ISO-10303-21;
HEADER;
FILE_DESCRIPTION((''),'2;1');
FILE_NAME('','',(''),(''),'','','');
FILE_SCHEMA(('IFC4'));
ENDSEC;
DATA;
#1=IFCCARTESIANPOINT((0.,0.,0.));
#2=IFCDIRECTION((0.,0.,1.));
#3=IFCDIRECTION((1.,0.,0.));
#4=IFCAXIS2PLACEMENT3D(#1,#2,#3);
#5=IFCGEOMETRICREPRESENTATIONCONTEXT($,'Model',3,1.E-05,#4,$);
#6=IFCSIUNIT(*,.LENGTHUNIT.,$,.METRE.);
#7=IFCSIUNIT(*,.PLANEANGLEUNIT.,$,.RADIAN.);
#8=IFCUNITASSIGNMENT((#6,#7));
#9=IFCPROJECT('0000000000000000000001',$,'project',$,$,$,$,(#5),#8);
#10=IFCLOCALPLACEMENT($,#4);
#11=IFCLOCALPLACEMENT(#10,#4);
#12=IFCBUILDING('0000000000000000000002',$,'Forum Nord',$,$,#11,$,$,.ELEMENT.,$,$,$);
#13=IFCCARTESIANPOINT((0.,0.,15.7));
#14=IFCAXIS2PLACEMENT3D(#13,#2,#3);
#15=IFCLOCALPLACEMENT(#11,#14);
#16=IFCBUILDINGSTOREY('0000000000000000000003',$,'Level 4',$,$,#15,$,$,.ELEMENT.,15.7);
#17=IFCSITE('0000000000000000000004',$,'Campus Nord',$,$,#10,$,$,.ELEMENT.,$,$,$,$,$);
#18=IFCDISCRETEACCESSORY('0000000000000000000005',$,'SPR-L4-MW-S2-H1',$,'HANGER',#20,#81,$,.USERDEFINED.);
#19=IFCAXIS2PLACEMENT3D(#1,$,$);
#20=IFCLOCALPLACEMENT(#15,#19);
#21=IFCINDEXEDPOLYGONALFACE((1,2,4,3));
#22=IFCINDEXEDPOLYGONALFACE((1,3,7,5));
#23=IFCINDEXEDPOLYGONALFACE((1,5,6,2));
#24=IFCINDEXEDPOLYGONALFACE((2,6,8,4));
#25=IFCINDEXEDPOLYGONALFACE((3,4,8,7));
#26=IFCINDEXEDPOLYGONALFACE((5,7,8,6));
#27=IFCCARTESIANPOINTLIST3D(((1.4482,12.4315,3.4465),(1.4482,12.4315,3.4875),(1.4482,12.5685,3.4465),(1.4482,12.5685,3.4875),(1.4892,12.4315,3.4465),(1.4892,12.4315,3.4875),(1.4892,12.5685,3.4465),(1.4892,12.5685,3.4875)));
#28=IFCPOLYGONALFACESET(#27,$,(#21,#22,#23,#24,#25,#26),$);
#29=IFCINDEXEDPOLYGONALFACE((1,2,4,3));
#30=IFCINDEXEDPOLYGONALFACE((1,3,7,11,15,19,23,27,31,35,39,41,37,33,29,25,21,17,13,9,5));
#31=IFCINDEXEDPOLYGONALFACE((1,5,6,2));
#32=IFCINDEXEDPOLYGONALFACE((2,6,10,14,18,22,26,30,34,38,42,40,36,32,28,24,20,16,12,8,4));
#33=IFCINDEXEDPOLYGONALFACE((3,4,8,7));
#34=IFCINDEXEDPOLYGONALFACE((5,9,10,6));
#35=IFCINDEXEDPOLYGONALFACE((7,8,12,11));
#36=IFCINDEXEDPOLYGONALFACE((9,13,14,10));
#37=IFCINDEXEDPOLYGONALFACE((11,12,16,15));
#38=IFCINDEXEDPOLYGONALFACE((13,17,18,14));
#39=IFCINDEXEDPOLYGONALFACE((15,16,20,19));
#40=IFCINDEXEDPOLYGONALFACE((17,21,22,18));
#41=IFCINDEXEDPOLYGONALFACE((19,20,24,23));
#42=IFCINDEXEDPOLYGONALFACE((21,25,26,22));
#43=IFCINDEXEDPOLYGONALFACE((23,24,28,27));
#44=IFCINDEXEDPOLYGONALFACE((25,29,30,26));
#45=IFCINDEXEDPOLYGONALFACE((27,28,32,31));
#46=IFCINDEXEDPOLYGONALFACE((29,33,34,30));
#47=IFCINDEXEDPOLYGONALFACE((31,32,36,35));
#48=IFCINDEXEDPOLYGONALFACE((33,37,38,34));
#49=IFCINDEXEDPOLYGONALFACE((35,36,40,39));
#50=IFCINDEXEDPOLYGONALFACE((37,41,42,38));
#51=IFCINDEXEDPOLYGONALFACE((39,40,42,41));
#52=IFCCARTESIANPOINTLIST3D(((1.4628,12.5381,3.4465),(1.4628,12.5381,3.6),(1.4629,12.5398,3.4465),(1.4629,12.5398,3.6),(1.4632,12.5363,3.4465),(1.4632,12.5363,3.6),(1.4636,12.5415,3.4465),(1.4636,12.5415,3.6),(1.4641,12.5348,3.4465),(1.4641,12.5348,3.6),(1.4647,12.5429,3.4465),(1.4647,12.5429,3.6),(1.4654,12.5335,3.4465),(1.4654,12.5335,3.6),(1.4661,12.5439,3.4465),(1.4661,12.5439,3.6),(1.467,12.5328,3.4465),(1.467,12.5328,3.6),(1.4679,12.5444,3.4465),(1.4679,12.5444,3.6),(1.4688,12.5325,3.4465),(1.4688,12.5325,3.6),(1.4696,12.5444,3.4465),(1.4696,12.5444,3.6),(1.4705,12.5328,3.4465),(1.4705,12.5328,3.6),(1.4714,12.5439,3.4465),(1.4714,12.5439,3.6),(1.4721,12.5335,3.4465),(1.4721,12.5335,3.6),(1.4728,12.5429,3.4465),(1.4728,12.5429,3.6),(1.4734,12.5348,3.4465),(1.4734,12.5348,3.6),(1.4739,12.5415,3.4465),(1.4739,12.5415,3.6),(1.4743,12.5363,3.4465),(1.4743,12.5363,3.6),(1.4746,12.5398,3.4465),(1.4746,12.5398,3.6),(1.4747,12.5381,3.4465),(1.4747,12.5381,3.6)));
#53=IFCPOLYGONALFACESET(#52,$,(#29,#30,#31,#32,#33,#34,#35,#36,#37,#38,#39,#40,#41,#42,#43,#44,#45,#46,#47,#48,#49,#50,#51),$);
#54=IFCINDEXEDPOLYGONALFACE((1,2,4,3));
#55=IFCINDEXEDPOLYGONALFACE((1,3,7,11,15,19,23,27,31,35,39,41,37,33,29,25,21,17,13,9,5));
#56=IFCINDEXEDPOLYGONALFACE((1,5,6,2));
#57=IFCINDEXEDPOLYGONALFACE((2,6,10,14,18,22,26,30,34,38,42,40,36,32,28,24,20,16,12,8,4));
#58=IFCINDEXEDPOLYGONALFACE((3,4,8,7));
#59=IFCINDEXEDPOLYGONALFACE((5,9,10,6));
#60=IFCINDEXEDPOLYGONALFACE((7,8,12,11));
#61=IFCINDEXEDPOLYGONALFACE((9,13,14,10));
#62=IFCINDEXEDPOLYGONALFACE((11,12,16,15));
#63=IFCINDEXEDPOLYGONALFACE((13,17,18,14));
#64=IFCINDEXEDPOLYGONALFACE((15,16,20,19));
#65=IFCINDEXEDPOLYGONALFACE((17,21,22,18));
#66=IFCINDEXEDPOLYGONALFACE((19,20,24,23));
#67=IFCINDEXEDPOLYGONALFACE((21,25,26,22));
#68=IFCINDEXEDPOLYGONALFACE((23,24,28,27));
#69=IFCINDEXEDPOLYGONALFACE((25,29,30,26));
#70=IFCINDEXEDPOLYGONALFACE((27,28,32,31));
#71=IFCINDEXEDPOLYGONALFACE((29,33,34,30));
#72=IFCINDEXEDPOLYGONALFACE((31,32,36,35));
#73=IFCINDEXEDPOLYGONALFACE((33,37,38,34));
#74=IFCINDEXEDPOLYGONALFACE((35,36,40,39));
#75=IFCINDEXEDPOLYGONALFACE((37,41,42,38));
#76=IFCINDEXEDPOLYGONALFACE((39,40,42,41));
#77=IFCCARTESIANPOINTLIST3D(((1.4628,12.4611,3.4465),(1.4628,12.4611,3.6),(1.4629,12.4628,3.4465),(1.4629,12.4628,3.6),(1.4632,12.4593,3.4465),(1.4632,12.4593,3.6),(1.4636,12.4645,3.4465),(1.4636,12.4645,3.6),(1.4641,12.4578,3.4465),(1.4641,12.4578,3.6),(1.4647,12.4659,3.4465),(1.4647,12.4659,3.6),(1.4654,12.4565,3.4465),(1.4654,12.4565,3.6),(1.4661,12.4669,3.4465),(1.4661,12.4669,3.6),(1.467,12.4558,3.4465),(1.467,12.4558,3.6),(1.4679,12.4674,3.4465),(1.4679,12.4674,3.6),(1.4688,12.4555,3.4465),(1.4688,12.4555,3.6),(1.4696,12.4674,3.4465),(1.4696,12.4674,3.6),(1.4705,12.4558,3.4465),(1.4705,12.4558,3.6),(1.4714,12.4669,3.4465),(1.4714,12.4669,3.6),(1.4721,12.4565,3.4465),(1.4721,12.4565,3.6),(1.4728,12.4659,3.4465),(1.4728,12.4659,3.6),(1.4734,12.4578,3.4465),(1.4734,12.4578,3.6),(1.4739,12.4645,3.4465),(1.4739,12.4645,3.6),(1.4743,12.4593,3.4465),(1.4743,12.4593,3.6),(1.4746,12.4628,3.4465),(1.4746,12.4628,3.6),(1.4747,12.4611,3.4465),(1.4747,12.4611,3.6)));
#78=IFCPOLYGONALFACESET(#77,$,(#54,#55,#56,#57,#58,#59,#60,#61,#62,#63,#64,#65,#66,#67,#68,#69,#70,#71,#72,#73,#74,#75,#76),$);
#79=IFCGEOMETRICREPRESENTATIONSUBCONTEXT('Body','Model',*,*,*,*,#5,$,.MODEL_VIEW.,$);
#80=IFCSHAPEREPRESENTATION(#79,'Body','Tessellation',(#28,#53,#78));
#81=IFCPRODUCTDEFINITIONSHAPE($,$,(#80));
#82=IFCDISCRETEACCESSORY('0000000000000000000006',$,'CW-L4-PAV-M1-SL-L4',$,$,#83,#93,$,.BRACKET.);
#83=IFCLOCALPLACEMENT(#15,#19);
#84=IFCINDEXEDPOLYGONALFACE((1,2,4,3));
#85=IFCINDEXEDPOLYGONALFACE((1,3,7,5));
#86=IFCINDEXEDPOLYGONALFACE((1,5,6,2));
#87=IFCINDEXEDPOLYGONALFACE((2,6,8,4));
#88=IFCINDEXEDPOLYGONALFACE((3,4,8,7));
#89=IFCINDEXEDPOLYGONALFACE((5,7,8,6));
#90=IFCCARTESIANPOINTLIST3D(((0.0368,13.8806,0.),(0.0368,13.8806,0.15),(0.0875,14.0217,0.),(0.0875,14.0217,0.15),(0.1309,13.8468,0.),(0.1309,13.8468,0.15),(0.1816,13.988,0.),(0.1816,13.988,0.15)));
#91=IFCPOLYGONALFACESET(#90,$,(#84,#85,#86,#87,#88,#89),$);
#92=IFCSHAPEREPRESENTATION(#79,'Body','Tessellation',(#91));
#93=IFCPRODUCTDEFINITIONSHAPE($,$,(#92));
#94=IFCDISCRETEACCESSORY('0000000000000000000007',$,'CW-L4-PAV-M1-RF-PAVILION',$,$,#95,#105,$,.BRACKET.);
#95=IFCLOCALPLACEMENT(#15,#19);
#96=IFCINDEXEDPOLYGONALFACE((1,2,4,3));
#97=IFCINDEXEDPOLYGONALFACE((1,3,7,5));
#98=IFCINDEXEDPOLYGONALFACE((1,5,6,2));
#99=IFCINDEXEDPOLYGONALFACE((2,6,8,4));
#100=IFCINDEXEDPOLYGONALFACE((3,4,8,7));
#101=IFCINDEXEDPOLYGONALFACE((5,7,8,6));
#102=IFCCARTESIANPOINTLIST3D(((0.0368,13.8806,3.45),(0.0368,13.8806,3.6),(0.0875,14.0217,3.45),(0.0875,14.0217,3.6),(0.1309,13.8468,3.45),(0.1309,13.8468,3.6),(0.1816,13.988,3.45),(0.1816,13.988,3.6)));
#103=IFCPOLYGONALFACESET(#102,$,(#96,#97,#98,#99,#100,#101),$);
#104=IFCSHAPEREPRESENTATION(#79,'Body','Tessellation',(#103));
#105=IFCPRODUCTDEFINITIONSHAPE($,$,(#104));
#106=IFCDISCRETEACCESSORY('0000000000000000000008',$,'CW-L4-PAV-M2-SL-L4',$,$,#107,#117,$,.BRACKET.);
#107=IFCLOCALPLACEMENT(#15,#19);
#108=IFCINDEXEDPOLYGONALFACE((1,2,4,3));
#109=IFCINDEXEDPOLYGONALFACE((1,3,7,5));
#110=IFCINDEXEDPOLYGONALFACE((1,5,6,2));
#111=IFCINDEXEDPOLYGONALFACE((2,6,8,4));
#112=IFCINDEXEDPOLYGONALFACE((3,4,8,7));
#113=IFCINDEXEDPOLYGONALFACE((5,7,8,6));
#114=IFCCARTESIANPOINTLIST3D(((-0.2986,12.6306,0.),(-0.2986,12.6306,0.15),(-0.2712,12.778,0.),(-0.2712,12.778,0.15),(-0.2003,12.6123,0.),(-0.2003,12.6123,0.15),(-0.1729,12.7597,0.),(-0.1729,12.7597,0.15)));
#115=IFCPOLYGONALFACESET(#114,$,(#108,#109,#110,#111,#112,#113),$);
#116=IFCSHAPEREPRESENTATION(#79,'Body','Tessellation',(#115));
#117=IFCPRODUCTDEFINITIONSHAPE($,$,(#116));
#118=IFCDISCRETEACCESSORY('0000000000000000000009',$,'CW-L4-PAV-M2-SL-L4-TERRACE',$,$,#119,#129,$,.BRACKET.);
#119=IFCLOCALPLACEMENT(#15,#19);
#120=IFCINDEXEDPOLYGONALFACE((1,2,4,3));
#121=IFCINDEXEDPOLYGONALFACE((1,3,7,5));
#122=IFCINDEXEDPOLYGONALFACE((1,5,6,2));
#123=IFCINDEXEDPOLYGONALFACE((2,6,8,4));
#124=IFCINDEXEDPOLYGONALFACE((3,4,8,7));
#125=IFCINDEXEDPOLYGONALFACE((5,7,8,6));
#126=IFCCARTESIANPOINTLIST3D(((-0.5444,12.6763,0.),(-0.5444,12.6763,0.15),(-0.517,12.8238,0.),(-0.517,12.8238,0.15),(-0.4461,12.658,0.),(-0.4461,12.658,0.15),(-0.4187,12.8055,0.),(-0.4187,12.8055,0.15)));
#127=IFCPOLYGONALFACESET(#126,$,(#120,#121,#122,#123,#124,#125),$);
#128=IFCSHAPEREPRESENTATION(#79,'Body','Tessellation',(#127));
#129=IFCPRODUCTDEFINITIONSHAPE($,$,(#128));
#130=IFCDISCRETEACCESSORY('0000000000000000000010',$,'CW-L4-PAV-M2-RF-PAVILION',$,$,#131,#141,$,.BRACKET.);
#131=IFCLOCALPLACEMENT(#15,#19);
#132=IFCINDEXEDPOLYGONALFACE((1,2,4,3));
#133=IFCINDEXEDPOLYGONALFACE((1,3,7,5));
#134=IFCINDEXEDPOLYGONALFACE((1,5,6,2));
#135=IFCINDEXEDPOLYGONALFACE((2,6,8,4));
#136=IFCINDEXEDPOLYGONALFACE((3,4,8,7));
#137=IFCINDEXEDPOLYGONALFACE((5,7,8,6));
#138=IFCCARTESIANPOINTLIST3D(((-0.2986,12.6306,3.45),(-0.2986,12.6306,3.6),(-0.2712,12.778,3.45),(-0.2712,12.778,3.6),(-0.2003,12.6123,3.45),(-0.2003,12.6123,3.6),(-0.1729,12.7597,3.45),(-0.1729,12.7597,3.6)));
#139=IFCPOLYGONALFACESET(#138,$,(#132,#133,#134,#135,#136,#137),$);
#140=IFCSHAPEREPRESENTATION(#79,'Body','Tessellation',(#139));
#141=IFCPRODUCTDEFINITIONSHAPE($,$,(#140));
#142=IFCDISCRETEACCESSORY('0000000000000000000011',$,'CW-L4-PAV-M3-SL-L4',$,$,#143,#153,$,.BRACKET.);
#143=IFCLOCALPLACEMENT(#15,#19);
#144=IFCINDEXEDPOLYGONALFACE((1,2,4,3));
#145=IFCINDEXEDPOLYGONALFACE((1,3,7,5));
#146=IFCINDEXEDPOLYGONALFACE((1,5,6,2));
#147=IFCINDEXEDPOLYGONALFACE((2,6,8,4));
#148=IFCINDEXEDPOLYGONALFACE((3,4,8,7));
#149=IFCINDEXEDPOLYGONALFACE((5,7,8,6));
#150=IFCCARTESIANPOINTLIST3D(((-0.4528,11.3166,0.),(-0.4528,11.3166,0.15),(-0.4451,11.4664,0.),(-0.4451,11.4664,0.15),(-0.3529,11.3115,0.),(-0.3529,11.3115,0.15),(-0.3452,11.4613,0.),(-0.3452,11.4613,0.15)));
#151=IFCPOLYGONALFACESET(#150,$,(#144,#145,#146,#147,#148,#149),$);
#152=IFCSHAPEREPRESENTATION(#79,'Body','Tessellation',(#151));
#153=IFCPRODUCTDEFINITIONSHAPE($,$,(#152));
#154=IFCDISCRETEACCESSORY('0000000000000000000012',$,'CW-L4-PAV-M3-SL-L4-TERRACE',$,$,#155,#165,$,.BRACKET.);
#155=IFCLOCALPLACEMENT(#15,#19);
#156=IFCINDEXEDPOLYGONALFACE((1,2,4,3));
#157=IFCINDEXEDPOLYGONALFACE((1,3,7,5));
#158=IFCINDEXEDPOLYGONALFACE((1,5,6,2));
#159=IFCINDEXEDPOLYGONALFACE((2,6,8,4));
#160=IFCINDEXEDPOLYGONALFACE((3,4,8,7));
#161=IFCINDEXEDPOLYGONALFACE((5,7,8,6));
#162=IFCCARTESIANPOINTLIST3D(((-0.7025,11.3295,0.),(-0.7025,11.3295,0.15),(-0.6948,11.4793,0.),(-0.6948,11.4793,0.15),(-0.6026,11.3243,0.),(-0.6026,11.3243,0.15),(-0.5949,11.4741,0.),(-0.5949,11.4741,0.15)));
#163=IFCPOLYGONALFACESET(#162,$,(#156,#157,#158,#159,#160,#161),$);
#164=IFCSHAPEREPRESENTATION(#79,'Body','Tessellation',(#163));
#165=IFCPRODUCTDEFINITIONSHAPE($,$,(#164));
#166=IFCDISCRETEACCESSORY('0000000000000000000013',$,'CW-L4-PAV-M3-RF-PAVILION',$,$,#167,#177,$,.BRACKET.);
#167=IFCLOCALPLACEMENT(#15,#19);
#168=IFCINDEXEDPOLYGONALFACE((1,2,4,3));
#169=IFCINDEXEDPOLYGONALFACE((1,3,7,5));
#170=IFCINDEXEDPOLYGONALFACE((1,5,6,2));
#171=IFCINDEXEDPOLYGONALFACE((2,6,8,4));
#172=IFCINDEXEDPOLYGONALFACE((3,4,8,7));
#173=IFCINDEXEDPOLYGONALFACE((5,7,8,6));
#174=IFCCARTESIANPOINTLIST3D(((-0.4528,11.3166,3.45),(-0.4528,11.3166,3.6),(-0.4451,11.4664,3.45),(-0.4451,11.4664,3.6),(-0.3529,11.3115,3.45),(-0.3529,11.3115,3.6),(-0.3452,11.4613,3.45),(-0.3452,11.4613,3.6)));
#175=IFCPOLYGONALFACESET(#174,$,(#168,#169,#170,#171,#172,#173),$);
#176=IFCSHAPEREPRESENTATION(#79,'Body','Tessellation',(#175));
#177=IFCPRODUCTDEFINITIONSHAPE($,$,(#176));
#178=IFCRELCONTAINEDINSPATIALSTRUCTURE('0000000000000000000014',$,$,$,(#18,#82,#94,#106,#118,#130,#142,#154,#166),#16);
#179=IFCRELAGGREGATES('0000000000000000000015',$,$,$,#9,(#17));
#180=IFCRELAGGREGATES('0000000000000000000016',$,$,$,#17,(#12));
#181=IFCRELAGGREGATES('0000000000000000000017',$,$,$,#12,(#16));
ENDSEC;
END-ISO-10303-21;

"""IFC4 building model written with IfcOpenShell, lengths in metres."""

from ifc_helpers import new_model, si_unit, frame, frame_2d, origin_with_axes, origin_2d_with_axis, place, context, subcontext, project, spatial, rectangle, circle, extrude, element, save


model = new_model("IFC4")

# Units and contexts
model_context = context("Model", 3, precision=1e-05, world=origin_with_axes())
body_context = subcontext(model_context, "Body", "Model", "MODEL_VIEW")
ifc_project = project(units=[si_unit("LENGTHUNIT", "METRE"), si_unit("PLANEANGLEUNIT", "RADIAN")], contexts=[model_context])

# Site, building, storey
site_placement = place(None, origin_with_axes())
site = spatial("IfcSite", under=ifc_project, at=site_placement, Name="Campus Nord", CompositionType="ELEMENT")
building_placement = place(site_placement, origin_with_axes())
building = spatial("IfcBuilding", under=site, at=building_placement, Name="Forum Nord", CompositionType="ELEMENT")
storey_placement = place(building_placement, frame((0.0, 0.0, 15.7), z_axis=(0.0, 0.0, 1.0), x_axis=(1.0, 0.0, 0.0)))
storey = spatial("IfcBuildingStorey", under=building, at=storey_placement, Name="Level 4", CompositionType="ELEMENT", Elevation=15.7)

# Discrete accessories
for number, where, z_axis, x_axis, name in (
    (1, (1.4688, 12.5, 3.4875), (0.0, 0.0, 1.0), (0.0, -1.0, 0.0), "SPR-L4-MW-S2-H1"),
):
    element("IfcDiscreteAccessory", number, at=place(storey_placement, frame(where, z_axis=z_axis, x_axis=x_axis)), inside=storey, Name=name, ObjectType="HANGER", PredefinedType="USERDEFINED", context=body_context, shape_type="SweptSolid", body=[
        extrude(rectangle(XDim=0.137, YDim=0.041, at=origin_2d_with_axis()), frame((0.0, 0.0, -0.041), z_axis=(0.0, 0.0, 1.0), x_axis=(1.0, 0.0, 0.0)), (0.0, 0.0, 1.0), 0.041),
        extrude(circle(Radius=0.006, at=frame_2d((-0.0385, 0.0), x_axis=(1.0, 0.0))), frame((0.0, 0.0, -0.041), z_axis=(0.0, 0.0, 1.0), x_axis=(1.0, 0.0, 0.0)), (0.0, 0.0, 1.0), 0.1535),
        extrude(circle(Radius=0.006, at=frame_2d((0.0385, 0.0), x_axis=(1.0, 0.0))), frame((0.0, 0.0, -0.041), z_axis=(0.0, 0.0, 1.0), x_axis=(1.0, 0.0, 0.0)), (0.0, 0.0, 1.0), 0.1535),
    ])
for number, where, z_axis, x_axis, name in (
    (2, (0.1092, 13.9343, 0.0), (0.0, 0.0, 1.0), (-0.33772, -0.94125, 0.0), "CW-L4-PAV-M1-SL-L4"),
    (3, (0.1092, 13.9343, 3.45), (0.0, 0.0, 1.0), (-0.33772, -0.94125, 0.0), "CW-L4-PAV-M1-RF-PAVILION"),
    (4, (-0.2358, 12.6951, 0.0), (0.0, 0.0, 1.0), (-0.18296, -0.98312, 0.0), "CW-L4-PAV-M2-SL-L4"),
    (5, (-0.4815, 12.7409, 0.0), (0.0, 0.0, 1.0), (-0.18296, -0.98312, 0.0), "CW-L4-PAV-M2-SL-L4-TERRACE"),
    (6, (-0.2358, 12.6951, 3.45), (0.0, 0.0, 1.0), (-0.18296, -0.98312, 0.0), "CW-L4-PAV-M2-RF-PAVILION"),
    (7, (-0.399, 11.3889, 0.0), (0.0, 0.0, 1.0), (-0.05151, -0.99867, 0.0), "CW-L4-PAV-M3-SL-L4"),
    (8, (-0.6487, 11.4018, 0.0), (0.0, 0.0, 1.0), (-0.05151, -0.99867, 0.0), "CW-L4-PAV-M3-SL-L4-TERRACE"),
    (9, (-0.399, 11.3889, 3.45), (0.0, 0.0, 1.0), (-0.05151, -0.99867, 0.0), "CW-L4-PAV-M3-RF-PAVILION"),
):
    element("IfcDiscreteAccessory", number, at=place(storey_placement, frame(where, z_axis=z_axis, x_axis=x_axis)), inside=storey, Name=name, PredefinedType="BRACKET", context=body_context, shape_type="SweptSolid", body=[
        extrude(rectangle(XDim=0.15, YDim=0.1, at=origin_2d_with_axis()), origin_with_axes(), (0.0, 0.0, 1.0), 0.15),
    ])

save(model, "model.ifc")
